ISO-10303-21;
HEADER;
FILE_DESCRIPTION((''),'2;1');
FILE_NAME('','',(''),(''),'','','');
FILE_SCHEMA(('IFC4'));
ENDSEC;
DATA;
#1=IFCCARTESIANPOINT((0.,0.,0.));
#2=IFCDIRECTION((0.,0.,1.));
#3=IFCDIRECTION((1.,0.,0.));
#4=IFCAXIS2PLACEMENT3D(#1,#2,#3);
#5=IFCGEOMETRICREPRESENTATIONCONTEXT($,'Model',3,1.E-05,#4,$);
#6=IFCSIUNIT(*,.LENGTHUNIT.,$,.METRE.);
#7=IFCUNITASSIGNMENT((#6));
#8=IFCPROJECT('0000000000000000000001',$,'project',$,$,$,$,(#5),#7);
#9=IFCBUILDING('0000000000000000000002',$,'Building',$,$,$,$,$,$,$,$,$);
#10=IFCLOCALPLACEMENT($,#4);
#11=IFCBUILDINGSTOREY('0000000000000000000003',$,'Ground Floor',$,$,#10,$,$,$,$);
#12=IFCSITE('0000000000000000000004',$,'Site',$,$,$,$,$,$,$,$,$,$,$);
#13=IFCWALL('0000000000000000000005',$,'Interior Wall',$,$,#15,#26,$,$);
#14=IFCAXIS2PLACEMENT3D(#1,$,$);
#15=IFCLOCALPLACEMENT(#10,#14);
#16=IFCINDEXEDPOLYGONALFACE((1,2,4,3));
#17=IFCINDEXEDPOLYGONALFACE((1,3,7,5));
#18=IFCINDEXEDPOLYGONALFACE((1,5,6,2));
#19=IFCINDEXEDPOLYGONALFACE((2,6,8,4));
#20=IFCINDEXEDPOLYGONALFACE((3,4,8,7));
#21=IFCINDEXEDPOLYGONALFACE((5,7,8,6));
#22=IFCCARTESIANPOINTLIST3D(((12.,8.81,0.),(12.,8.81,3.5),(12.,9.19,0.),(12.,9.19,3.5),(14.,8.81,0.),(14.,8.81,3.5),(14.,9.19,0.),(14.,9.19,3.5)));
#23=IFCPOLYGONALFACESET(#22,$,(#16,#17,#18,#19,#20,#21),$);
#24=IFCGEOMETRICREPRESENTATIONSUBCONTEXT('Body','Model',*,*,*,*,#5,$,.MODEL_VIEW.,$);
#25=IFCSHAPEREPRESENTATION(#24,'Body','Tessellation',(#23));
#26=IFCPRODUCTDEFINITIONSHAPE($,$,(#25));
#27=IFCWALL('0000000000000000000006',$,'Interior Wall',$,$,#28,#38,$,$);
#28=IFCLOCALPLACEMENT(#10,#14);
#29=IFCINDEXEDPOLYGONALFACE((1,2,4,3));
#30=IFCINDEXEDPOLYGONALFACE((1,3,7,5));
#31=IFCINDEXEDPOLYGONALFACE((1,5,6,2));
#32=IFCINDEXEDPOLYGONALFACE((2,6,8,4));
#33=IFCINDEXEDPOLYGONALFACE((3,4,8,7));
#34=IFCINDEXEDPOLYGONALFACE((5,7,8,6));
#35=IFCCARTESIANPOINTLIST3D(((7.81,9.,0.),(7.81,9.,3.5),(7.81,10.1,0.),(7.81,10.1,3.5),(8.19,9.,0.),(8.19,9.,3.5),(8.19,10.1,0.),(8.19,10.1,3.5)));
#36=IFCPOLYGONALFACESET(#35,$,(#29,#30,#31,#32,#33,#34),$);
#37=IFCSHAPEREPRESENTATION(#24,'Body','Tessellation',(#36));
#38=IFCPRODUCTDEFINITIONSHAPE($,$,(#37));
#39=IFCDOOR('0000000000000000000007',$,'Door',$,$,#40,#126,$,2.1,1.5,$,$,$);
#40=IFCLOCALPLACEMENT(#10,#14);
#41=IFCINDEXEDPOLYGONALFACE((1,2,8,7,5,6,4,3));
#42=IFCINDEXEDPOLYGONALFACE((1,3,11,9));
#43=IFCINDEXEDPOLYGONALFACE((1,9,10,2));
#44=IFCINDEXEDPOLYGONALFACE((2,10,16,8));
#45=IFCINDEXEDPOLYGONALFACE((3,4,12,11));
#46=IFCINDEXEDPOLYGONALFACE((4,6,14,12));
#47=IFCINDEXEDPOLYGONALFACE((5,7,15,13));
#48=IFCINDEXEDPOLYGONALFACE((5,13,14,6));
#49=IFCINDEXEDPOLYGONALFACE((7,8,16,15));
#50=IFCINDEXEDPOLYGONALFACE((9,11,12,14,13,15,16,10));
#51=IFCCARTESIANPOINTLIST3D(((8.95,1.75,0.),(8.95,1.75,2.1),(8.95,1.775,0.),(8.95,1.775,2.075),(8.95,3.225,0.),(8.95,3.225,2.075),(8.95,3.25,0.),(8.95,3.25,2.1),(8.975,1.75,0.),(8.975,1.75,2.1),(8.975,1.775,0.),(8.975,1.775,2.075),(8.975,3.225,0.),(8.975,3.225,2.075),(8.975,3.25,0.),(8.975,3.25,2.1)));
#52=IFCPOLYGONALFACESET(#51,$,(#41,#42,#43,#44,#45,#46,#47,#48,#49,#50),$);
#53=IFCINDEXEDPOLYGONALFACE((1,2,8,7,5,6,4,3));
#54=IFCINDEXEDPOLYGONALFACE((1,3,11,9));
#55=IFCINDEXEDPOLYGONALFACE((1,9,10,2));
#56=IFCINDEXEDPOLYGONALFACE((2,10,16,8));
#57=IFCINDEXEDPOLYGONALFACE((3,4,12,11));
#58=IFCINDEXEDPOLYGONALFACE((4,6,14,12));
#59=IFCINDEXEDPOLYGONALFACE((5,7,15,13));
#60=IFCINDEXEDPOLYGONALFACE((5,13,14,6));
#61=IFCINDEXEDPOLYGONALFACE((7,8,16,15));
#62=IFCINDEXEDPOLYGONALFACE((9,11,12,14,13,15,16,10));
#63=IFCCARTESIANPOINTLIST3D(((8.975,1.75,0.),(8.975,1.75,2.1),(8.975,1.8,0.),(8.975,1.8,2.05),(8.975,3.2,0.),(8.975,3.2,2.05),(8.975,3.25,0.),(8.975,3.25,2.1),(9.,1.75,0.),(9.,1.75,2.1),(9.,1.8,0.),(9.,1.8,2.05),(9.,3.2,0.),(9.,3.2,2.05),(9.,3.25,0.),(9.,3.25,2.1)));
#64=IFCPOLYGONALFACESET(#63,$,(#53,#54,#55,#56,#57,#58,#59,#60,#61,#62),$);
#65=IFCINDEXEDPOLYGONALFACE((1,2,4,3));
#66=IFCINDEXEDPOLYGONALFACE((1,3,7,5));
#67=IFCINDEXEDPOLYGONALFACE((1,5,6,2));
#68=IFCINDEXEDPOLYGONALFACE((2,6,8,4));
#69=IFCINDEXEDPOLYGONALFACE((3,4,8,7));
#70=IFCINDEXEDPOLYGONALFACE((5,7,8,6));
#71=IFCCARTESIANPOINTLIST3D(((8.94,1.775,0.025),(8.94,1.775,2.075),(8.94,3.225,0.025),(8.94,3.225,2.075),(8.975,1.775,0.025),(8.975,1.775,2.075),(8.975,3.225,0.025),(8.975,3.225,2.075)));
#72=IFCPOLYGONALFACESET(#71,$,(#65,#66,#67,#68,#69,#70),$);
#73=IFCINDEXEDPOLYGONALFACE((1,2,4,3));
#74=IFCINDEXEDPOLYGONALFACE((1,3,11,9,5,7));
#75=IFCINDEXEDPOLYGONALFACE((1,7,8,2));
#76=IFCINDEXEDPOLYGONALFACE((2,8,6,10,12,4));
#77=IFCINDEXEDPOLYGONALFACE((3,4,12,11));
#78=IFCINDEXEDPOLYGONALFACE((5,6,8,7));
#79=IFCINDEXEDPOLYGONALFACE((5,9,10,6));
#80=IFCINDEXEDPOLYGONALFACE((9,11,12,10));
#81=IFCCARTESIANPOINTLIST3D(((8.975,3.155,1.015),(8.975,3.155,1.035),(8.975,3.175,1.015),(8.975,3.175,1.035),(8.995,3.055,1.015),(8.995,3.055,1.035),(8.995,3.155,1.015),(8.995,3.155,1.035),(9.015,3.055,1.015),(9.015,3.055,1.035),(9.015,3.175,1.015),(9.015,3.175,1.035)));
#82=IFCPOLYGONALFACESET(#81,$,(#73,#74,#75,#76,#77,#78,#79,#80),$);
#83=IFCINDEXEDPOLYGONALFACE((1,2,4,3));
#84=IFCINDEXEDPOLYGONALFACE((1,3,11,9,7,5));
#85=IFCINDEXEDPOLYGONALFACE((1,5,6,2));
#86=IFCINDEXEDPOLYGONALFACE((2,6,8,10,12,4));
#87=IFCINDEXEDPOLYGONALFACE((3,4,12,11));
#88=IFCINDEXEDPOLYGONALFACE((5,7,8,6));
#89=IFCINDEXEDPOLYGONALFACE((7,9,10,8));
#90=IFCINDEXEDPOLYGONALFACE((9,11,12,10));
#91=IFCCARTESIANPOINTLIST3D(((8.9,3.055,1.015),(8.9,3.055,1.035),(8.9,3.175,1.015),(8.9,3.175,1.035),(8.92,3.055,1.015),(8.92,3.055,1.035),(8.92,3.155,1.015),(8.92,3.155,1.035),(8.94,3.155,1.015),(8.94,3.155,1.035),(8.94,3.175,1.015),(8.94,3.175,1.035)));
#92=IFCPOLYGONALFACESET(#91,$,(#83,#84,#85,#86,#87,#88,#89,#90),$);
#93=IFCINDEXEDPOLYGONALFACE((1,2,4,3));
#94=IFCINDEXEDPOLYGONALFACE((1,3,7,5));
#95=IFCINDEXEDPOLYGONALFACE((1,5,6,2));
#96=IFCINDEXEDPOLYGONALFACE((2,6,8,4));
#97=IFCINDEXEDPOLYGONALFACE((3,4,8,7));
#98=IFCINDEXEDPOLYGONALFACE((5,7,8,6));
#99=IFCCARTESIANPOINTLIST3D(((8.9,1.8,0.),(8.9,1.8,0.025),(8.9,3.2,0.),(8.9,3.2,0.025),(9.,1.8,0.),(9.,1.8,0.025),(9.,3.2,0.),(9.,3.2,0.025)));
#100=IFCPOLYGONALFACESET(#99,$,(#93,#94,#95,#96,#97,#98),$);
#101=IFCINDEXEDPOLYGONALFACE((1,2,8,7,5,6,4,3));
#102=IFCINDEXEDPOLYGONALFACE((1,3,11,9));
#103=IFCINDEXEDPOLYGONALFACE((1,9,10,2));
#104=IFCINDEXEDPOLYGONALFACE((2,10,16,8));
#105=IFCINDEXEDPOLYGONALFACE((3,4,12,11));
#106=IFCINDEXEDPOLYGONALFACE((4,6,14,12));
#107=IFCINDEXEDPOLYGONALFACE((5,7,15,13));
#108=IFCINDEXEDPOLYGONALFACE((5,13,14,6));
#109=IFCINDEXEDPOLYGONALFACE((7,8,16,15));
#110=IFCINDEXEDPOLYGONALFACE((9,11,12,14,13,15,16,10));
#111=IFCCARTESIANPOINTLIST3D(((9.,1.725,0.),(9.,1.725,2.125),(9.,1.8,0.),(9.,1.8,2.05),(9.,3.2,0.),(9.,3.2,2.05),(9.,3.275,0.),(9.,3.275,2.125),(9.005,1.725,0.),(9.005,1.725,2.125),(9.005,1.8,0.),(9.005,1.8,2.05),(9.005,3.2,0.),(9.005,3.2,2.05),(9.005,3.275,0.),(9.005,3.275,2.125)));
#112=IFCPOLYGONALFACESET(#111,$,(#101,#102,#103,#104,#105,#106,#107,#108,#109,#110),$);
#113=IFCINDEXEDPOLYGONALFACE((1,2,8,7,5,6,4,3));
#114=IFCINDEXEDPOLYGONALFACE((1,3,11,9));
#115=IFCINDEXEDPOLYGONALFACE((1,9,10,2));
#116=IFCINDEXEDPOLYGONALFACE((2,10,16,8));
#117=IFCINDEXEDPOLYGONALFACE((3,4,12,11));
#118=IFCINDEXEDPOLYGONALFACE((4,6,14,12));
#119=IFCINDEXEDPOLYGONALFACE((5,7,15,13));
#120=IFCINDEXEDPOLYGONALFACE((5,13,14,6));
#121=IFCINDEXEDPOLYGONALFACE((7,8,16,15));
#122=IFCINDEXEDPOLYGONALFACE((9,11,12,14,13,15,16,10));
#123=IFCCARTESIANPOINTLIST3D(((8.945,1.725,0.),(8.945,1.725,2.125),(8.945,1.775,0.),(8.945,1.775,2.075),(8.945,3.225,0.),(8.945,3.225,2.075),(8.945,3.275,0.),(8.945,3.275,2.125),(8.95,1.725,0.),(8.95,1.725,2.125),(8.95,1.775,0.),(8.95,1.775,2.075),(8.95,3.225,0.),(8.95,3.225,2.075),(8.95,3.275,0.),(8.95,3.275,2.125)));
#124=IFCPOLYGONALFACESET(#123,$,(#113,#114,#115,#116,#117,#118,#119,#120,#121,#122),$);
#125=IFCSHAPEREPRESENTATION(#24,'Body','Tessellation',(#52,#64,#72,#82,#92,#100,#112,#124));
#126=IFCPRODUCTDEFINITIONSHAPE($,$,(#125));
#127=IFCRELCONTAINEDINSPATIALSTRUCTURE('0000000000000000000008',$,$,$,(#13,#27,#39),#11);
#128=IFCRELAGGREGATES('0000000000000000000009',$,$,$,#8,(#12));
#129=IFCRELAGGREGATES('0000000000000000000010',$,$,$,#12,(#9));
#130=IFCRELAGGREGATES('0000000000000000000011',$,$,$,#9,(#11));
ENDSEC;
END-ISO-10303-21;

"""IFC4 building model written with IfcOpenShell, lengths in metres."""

from ifc_helpers import new_model, si_unit, frame, origin_with_axes, place, context, subcontext, project, spatial, line, indexed_curve, outline, extrude, element, save


model = new_model("IFC4")

# Units and contexts
model_context = context("Model", 3, precision=1e-05, world=origin_with_axes())
body_context = subcontext(model_context, "Body", "Model", "MODEL_VIEW")
ifc_project = project(units=[si_unit("LENGTHUNIT", "METRE")], contexts=[model_context])

# Site, building, storey
site = spatial("IfcSite", under=ifc_project, Name="Site")
building = spatial("IfcBuilding", under=site, Name="Building")
storey_placement = place(None, origin_with_axes())
storey = spatial("IfcBuildingStorey", under=building, at=storey_placement, Name="Ground Floor")

# Walls
wall_1_placement = place(storey_placement, frame((14.0, 9.0, 0.0), z_axis=(0.0, 0.0, 1.0), x_axis=(-1.0, 0.0, 0.0)))
element("IfcWall", 1, at=wall_1_placement, inside=storey, Name="Interior Wall", context=body_context, shape_type="SweptSolid", body=[
    extrude(outline(indexed_curve([(0.0, 0.0), (0.0, 0.38), (2.0, 0.38), (2.0, 0.0), (0.0, 0.0)], self_intersect=False)), frame((0.0, -0.19, 0.0), z_axis=(0.0, 0.0, 1.0), x_axis=(1.0, 0.0, 0.0)), (0.0, 0.0, 1.0), 3.5),
])
wall_2_placement = place(storey_placement, frame((8.0, 9.0, 0.0), z_axis=(0.0, 0.0, 1.0), x_axis=(0.0, 1.0, 0.0)))
element("IfcWall", 2, at=wall_2_placement, inside=storey, Name="Interior Wall", context=body_context, shape_type="SweptSolid", body=[
    extrude(outline(indexed_curve([(0.0, 0.0), (0.0, 0.38), (1.1, 0.38), (1.1, 0.0), (0.0, 0.0)], self_intersect=False)), frame((0.0, -0.19, 0.0), z_axis=(0.0, 0.0, 1.0), x_axis=(1.0, 0.0, 0.0)), (0.0, 0.0, 1.0), 3.5),
])

# Door
door_1_placement = place(storey_placement, frame((9.0, 1.75, 0.0), z_axis=(0.0, 0.0, 1.0), x_axis=(0.0, 1.0, 0.0)))
element("IfcDoor", 3, at=door_1_placement, inside=storey, Name="Door", OverallHeight=2.1, OverallWidth=1.5, context=body_context, shape_type="SweptSolid", body=[
    extrude(outline(indexed_curve([(0.0, 0.0), (0.0, 2.1), (1.5, 2.1), (1.5, 0.0), (1.475, 0.0), (1.475, 2.075), (0.025, 2.075), (0.025, 0.0)], segments=[line(1, 2, 3, 4, 5, 6, 7, 8, 1)])), frame((0.0, 0.025, 0.0), z_axis=(0.0, -1.0, 0.0), x_axis=(1.0, 0.0, 0.0)), (0.0, 0.0, -1.0), 0.025),
    extrude(outline(indexed_curve([(0.0, 0.0), (0.0, 2.1), (1.5, 2.1), (1.5, 0.0), (1.45, 0.0), (1.45, 2.05), (0.05, 2.05), (0.05, 0.0)], segments=[line(1, 2, 3, 4, 5, 6, 7, 8, 1)])), frame((0.0, 0.0, 0.0), z_axis=(0.0, -1.0, 0.0), x_axis=(1.0, 0.0, 0.0)), (0.0, 0.0, -1.0), 0.025),
    extrude(outline(indexed_curve([(0.0, 0.0), (1.45, 0.0), (1.45, 0.035), (0.0, 0.035)], segments=[line(1, 2, 3, 4, 1)])), frame((0.025, 0.025, 0.025), z_axis=(0.0, 0.0, 1.0), x_axis=(1.0, 0.0, 0.0)), (0.0, 0.0, 1.0), 2.05),
    extrude(outline(indexed_curve([(0.0, 0.0), (0.0, -0.04), (-0.12, -0.04), (-0.12, -0.02), (-0.02, -0.02), (-0.02, 0.0)], segments=[line(1, 2, 3, 4, 5, 6, 1)])), frame((1.425, 0.025, 1.015), z_axis=(0.0, 0.0, 1.0), x_axis=(1.0, 0.0, 0.0)), (0.0, 0.0, 1.0), 0.02),
    extrude(outline(indexed_curve([(0.0, 0.0), (0.0, 0.04), (-0.12, 0.04), (-0.12, 0.02), (-0.02, 0.02), (-0.02, 0.0)], segments=[line(1, 2, 3, 4, 5, 6, 1)])), frame((1.425, 0.06, 1.015), z_axis=(0.0, 0.0, 1.0), x_axis=(1.0, 0.0, 0.0)), (0.0, 0.0, 1.0), 0.02),
    extrude(outline(indexed_curve([(0.0, 0.0), (1.4, 0.0), (1.4, 0.1), (0.0, 0.1)], segments=[line(1, 2, 3, 4, 1)])), frame((0.05, 0.0, 0.0), z_axis=(0.0, 0.0, 1.0), x_axis=(1.0, 0.0, 0.0)), (0.0, 0.0, 1.0), 0.025),
    extrude(outline(indexed_curve([(0.0, 0.0), (0.0, 2.125), (1.55, 2.125), (1.55, 0.0), (1.475, 0.0), (1.475, 2.05), (0.075, 2.05), (0.075, 0.0)], segments=[line(1, 2, 3, 4, 5, 6, 7, 8, 1)])), frame((-0.025, -0.005, 0.0), z_axis=(0.0, -1.0, 0.0), x_axis=(1.0, 0.0, 0.0)), (0.0, 0.0, -1.0), 0.005),
    extrude(outline(indexed_curve([(0.0, 0.0), (0.0, 2.125), (1.55, 2.125), (1.55, 0.0), (1.5, 0.0), (1.5, 2.075), (0.05, 2.075), (0.05, 0.0)], segments=[line(1, 2, 3, 4, 5, 6, 7, 8, 1)])), frame((-0.025, 0.05, 0.0), z_axis=(0.0, -1.0, 0.0), x_axis=(1.0, 0.0, 0.0)), (0.0, 0.0, -1.0), 0.005),
])

save(model, "model.ifc")
